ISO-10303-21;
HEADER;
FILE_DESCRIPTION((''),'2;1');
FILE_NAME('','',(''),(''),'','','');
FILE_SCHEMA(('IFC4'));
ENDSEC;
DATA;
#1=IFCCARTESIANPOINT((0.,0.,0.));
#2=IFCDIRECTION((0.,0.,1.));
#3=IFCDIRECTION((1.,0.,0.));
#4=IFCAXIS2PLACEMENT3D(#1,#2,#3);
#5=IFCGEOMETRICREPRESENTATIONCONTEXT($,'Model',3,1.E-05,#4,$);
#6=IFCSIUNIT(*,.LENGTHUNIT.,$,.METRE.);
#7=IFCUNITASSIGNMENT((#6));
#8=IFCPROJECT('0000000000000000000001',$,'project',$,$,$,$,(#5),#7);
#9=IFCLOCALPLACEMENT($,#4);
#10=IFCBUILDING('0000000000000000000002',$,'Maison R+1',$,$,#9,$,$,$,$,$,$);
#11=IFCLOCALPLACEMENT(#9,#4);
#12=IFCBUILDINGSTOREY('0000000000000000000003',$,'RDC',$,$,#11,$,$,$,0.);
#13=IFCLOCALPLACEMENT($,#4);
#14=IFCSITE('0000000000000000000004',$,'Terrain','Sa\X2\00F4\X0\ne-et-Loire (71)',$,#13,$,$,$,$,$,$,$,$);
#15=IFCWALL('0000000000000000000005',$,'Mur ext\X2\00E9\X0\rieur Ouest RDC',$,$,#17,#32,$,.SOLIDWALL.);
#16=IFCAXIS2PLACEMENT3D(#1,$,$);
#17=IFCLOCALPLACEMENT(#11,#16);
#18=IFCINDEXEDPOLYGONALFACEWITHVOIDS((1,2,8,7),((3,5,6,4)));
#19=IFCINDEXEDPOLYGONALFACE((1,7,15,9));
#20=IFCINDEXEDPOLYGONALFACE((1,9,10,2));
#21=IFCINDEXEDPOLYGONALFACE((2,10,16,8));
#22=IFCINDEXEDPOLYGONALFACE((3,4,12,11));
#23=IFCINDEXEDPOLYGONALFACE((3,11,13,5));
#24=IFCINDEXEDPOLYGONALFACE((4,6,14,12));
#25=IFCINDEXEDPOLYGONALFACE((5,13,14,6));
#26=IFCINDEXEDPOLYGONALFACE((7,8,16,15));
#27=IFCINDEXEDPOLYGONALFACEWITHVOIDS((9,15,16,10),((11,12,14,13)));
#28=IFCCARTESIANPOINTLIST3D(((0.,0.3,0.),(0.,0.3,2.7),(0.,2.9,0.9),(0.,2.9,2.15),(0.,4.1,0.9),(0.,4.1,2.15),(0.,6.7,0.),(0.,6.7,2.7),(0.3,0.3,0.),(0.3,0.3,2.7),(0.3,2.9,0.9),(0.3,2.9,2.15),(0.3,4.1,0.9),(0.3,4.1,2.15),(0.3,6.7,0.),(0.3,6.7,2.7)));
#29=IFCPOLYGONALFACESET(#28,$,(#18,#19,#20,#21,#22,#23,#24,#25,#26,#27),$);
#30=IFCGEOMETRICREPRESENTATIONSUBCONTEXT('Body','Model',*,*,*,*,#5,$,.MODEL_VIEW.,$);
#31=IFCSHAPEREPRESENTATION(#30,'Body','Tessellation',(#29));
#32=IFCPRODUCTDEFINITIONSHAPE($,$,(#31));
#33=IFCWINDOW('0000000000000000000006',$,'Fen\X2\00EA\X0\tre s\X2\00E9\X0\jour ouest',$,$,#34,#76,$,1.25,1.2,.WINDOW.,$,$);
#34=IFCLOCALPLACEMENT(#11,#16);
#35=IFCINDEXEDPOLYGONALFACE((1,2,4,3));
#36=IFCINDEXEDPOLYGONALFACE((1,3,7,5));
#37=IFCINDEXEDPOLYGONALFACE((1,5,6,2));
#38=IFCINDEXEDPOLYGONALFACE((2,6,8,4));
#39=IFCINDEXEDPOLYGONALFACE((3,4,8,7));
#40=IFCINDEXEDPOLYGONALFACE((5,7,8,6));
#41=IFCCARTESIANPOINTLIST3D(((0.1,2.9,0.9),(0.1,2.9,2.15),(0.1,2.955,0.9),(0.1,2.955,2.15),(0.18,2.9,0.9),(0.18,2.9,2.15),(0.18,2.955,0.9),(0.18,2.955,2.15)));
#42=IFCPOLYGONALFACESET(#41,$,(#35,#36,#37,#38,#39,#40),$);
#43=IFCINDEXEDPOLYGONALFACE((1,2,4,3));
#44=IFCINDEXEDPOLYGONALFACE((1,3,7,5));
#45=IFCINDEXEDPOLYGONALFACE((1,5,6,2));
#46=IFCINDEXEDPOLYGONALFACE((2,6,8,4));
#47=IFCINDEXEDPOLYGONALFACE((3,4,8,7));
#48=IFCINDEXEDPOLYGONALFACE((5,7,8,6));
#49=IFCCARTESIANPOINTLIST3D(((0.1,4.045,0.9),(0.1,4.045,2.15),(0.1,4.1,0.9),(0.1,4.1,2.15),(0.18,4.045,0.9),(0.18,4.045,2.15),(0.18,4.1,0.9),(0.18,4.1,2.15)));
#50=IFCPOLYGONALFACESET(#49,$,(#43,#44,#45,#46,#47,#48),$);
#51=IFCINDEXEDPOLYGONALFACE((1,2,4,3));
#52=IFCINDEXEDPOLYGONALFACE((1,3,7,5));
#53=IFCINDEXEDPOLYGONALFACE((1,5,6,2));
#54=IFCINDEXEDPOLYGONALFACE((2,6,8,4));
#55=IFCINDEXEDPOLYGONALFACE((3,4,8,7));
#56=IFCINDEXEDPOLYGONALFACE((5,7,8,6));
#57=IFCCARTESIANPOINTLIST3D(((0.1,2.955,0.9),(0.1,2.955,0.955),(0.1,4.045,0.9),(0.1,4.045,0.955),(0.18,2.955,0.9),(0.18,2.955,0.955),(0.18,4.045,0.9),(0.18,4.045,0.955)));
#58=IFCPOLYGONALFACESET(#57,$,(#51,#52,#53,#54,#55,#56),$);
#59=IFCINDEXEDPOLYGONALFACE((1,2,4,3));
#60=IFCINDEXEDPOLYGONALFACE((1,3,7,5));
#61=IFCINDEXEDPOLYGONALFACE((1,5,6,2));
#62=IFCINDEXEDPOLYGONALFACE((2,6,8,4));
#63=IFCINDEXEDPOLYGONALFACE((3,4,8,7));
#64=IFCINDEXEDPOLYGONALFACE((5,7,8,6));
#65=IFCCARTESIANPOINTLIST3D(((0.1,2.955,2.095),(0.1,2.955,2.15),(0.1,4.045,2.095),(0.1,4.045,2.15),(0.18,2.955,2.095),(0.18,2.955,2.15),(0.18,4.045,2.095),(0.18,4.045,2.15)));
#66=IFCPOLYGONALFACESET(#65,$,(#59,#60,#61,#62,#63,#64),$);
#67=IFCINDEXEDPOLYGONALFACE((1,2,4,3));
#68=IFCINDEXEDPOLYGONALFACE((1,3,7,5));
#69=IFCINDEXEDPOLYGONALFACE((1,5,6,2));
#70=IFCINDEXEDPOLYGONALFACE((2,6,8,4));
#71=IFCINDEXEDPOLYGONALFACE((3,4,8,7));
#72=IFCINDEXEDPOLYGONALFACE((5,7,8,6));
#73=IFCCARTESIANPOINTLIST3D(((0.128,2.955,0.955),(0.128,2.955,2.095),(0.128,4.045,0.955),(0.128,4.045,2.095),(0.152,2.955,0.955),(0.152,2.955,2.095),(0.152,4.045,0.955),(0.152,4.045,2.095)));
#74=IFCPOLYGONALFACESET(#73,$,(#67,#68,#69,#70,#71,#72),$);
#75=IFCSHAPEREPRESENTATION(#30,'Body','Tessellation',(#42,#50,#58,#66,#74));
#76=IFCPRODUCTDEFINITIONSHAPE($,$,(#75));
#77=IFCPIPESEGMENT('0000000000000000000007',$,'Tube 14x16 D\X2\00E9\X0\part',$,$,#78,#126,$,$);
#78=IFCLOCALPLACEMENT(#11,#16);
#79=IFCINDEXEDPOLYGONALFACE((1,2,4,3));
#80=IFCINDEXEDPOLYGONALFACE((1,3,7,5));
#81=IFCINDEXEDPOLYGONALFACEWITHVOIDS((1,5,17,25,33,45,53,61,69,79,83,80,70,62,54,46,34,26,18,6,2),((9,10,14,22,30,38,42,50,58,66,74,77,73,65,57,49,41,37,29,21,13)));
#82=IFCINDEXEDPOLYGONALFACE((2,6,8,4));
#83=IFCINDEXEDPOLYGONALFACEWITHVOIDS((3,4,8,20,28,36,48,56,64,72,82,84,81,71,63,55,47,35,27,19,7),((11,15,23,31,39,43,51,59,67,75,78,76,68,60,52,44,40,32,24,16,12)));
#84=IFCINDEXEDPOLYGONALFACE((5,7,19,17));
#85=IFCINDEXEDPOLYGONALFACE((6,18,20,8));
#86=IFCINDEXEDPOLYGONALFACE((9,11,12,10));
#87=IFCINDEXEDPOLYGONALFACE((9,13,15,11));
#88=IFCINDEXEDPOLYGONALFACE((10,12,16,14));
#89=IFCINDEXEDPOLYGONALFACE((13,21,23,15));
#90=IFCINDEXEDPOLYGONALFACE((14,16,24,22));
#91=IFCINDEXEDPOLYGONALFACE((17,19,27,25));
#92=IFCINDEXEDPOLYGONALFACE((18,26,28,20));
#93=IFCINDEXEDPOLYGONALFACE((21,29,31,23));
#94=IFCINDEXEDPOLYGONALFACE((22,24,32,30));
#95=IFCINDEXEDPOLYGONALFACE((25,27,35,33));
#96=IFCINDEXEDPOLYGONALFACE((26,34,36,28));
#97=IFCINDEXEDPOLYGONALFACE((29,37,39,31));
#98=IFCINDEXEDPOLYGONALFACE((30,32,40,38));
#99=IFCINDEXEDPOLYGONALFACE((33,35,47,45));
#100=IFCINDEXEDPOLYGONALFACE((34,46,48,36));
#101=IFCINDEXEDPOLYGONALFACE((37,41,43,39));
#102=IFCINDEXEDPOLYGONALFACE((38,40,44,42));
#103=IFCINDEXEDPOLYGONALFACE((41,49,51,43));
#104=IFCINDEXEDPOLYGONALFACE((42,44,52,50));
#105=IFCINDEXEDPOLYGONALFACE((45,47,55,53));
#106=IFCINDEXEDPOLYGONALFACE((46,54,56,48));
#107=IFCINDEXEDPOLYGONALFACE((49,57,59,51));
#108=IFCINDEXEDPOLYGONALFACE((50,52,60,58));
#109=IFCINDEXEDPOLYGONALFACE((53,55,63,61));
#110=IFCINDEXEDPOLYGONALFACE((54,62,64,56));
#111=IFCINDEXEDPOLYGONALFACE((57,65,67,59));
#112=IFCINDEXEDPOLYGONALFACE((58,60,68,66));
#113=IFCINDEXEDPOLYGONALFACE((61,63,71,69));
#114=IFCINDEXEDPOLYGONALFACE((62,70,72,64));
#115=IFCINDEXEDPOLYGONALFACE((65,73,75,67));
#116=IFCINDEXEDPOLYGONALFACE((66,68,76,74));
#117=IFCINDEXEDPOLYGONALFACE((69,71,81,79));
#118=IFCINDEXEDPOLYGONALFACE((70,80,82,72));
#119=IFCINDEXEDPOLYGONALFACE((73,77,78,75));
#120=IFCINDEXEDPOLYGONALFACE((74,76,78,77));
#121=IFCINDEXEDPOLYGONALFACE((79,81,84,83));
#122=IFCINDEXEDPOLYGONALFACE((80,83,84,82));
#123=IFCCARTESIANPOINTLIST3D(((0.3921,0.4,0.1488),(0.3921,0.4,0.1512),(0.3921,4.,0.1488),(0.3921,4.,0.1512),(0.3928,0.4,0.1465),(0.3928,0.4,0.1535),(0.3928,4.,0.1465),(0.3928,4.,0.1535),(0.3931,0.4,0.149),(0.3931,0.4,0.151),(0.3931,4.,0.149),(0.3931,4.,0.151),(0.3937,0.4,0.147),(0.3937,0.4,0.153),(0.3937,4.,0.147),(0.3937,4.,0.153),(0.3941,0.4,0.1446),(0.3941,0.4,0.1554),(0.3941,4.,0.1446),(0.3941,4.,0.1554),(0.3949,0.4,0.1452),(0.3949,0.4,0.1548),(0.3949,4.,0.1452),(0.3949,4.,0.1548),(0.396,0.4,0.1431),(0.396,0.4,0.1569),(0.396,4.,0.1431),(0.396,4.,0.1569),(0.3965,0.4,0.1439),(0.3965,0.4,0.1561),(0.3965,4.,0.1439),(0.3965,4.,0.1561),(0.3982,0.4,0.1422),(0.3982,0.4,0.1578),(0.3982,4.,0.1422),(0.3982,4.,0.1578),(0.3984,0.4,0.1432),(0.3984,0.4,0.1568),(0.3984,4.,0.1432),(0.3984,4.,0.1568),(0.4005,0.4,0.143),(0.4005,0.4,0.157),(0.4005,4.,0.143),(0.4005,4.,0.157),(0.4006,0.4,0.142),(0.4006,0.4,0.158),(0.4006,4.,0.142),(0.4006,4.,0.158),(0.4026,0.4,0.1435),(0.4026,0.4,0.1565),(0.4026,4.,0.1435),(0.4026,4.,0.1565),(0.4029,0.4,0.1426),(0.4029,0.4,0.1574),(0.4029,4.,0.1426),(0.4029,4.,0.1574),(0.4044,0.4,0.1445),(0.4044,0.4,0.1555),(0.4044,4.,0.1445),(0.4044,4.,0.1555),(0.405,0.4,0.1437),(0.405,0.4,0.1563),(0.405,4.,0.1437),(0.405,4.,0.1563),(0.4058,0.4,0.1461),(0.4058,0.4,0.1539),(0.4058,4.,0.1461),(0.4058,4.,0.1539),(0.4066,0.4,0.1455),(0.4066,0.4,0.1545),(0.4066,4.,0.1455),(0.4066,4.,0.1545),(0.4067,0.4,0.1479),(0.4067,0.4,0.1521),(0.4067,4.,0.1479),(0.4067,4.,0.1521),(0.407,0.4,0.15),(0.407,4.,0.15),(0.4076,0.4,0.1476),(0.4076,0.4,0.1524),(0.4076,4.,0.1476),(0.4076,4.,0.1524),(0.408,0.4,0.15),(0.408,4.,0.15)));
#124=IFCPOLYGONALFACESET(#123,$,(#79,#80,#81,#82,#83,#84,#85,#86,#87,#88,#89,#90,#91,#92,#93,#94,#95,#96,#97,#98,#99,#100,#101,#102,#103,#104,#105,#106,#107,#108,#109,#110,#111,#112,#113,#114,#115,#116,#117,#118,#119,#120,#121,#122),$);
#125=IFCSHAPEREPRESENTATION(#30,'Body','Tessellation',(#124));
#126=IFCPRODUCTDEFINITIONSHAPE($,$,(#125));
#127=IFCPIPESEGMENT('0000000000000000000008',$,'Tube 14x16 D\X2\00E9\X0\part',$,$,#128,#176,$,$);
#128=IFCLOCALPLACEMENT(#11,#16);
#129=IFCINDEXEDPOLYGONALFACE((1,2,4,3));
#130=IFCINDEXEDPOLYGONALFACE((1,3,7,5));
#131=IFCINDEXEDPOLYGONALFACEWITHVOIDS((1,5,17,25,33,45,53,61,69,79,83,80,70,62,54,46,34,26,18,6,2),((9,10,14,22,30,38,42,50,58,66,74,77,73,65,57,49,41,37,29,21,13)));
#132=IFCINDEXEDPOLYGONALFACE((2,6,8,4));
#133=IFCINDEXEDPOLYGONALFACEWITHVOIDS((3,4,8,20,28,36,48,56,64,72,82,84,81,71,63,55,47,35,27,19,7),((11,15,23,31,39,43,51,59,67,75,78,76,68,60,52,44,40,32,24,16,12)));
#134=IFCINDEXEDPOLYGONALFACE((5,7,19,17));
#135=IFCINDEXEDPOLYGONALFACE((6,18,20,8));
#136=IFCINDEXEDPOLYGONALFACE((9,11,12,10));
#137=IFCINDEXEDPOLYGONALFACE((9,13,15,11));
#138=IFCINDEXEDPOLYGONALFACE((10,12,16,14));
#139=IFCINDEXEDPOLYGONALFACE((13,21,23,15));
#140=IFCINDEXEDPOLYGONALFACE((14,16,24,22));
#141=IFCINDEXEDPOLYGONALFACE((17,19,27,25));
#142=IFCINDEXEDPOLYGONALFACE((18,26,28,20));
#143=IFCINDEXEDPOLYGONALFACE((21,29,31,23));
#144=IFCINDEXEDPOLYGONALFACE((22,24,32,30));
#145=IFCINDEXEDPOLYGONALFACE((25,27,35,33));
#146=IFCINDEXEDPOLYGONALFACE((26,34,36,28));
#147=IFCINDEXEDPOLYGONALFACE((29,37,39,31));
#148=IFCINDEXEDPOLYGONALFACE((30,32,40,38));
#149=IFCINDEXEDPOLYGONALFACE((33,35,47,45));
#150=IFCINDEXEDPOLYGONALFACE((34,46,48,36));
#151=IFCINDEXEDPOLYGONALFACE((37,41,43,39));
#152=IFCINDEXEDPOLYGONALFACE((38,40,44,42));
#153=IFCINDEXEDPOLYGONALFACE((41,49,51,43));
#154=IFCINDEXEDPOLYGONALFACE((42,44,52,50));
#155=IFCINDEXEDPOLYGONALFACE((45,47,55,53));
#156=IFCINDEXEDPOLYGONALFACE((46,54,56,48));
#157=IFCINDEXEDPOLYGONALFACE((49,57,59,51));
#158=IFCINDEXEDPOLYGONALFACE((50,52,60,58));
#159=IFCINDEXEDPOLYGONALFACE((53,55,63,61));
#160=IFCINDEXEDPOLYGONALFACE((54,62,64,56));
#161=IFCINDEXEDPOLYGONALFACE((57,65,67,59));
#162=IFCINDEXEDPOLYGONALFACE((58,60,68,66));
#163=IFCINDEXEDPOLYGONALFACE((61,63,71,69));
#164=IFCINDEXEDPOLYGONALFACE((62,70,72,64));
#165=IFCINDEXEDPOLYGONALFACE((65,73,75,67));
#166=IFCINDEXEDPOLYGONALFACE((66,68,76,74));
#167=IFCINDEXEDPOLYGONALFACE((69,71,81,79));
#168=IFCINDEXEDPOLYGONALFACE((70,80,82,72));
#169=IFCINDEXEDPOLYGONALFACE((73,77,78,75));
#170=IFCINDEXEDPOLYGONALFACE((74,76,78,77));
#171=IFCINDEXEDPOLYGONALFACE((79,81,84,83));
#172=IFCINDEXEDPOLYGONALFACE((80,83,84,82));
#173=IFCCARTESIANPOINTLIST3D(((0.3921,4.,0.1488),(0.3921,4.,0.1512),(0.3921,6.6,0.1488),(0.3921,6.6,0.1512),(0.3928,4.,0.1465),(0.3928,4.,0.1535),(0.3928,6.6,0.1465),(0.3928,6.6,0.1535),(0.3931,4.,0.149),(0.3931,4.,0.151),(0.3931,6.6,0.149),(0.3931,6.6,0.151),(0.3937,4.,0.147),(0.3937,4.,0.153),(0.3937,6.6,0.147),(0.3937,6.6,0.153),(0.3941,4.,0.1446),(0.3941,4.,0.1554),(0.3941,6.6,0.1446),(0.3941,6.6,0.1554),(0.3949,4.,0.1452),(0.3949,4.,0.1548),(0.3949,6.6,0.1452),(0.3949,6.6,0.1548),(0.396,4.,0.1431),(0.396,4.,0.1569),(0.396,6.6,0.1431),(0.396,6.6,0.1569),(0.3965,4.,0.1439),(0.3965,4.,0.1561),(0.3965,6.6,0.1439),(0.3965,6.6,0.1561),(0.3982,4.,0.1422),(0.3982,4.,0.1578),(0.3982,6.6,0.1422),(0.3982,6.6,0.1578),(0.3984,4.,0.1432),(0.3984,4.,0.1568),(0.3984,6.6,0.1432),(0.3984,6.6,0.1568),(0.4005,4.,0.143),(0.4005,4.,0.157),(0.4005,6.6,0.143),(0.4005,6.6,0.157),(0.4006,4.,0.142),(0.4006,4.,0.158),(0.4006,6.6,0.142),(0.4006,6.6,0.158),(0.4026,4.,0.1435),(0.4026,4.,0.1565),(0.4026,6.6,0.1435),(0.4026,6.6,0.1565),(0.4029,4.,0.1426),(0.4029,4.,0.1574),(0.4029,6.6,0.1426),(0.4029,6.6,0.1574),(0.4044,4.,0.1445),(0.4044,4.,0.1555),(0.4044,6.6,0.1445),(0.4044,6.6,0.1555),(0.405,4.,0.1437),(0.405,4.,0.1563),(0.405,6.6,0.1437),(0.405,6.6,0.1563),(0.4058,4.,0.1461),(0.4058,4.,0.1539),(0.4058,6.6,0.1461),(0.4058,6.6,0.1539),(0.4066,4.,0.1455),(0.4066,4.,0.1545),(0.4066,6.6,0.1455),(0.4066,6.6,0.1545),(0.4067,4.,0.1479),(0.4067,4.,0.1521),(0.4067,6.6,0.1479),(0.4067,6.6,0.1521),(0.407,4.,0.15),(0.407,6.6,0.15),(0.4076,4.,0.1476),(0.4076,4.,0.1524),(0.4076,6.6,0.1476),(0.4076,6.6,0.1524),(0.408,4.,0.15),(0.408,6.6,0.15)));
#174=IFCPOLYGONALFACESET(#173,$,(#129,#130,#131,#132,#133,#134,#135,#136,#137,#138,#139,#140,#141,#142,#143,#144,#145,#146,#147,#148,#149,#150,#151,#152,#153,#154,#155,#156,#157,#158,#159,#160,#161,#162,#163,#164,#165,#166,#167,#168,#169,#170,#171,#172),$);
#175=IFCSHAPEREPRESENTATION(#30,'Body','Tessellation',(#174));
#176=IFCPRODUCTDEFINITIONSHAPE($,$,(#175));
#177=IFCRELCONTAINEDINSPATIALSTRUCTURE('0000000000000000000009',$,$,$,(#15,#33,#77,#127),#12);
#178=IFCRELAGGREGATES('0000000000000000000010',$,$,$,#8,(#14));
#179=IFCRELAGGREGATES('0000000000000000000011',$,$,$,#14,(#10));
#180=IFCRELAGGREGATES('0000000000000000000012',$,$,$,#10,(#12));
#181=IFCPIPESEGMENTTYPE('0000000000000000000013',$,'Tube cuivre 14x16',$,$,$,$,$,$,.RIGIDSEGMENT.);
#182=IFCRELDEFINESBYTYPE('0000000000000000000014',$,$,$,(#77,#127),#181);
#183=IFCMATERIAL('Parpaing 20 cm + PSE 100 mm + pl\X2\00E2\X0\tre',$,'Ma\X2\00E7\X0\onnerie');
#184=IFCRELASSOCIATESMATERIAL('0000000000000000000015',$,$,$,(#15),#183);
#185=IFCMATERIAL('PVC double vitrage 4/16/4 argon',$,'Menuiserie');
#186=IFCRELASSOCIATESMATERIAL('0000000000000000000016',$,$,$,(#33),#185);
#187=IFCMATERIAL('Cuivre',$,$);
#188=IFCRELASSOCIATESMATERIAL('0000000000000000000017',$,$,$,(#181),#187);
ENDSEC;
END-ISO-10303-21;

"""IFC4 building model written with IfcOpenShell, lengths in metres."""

from ifc_helpers import new_model, si_unit, frame, frame_2d, origin_with_axes, place, context, subcontext, project, spatial, rectangle, hollow_circle, extrude, material, type_object, element, fill, save


model = new_model("IFC4")

# Units and contexts
model_context = context("Model", 3, precision=1e-05, world=origin_with_axes())
body_context = subcontext(model_context, "Body", "Model", "MODEL_VIEW")
ifc_project = project(units=[si_unit("LENGTHUNIT", "METRE")], contexts=[model_context])

# Site, building, storey
site_placement = place(None, origin_with_axes())
site = spatial("IfcSite", under=ifc_project, at=site_placement, Name="Terrain", Description="Saône-et-Loire (71)")
building_placement = place(None, origin_with_axes())
building = spatial("IfcBuilding", under=site, at=building_placement, Name="Maison R+1")
storey_placement = place(building_placement, origin_with_axes())
storey = spatial("IfcBuildingStorey", under=building, at=storey_placement, Name="RDC", Elevation=0.0)

# Shared definitions
ifc_material_1 = material(Name="Parpaing 20 cm + PSE 100 mm + plâtre", Category="Maçonnerie")
ifc_material_2 = material(Name="PVC double vitrage 4/16/4 argon", Category="Menuiserie")

# Wall, opening, window
wall_1_placement = place(storey_placement, frame((0.0, 0.3, 0.0), z_axis=(0.0, 0.0, 1.0), x_axis=(1.0, 0.0, 0.0)))
wall_1 = element("IfcWall", 1, at=wall_1_placement, inside=storey, material=ifc_material_1, Name="Mur extérieur Ouest RDC", PredefinedType="SOLIDWALL", context=body_context, shape_type="SweptSolid", body=[
    extrude(rectangle(XDim=0.3, YDim=6.4, at=frame_2d((0.15, 3.2))), origin_with_axes(), (0.0, 0.0, 1.0), 2.7),
])
opening_1_placement = place(storey_placement, frame((-0.05, 2.9, 0.9), z_axis=(0.0, 0.0, 1.0), x_axis=(1.0, 0.0, 0.0)))
opening_1 = element("IfcOpeningElement", 2, at=opening_1_placement, cuts=wall_1, context=body_context, shape_type="SweptSolid", body=[
    extrude(rectangle(XDim=0.4, YDim=1.2, at=frame_2d((0.2, 0.6))), origin_with_axes(), (0.0, 0.0, 1.0), 1.25),
])
window_1_placement = place(storey_placement, frame((0.1, 2.9, 0.9), z_axis=(0.0, 0.0, 1.0), x_axis=(1.0, 0.0, 0.0)))
window_1 = element("IfcWindow", 3, at=window_1_placement, inside=storey, material=ifc_material_2, Name="Fenêtre séjour ouest", OverallHeight=1.25, OverallWidth=1.2, PredefinedType="WINDOW", context=body_context, shape_type="SweptSolid", body=[
    extrude(rectangle(XDim=0.08, YDim=0.055, at=frame_2d((0.04, 0.0275))), origin_with_axes(), (0.0, 0.0, 1.0), 1.25),
    extrude(rectangle(XDim=0.08, YDim=0.055, at=frame_2d((0.04, 0.0275))), frame((0.0, 1.145, 0.0), z_axis=(0.0, 0.0, 1.0), x_axis=(1.0, 0.0, 0.0)), (0.0, 0.0, 1.0), 1.25),
    extrude(rectangle(XDim=0.08, YDim=1.09, at=frame_2d((0.04, 0.545))), frame((0.0, 0.055, 0.0), z_axis=(0.0, 0.0, 1.0), x_axis=(1.0, 0.0, 0.0)), (0.0, 0.0, 1.0), 0.055),
    extrude(rectangle(XDim=0.08, YDim=1.09, at=frame_2d((0.04, 0.545))), frame((0.0, 0.055, 1.195), z_axis=(0.0, 0.0, 1.0), x_axis=(1.0, 0.0, 0.0)), (0.0, 0.0, 1.0), 0.055),
    extrude(rectangle(XDim=0.024, YDim=1.09, at=frame_2d((0.012, 0.545))), frame((0.028, 0.055, 0.055), z_axis=(0.0, 0.0, 1.0), x_axis=(1.0, 0.0, 0.0)), (0.0, 0.0, 1.0), 1.14),
])
fill(opening_1, window_1)

# Pipe segments
ifc_material_3 = material(Name="Cuivre")
pipe_segment_type_1 = type_object("IfcPipeSegmentType", Name="Tube cuivre 14x16", PredefinedType="RIGIDSEGMENT", material=ifc_material_3)
pipe_segment_1_placement = place(storey_placement, frame((0.4, 0.4, 0.15), z_axis=(0.0, 1.0, 0.0), x_axis=(1.0, 0.0, 0.0)))
element("IfcPipeSegment", 4, at=pipe_segment_1_placement, inside=storey, type_object=pipe_segment_type_1, Name="Tube 14x16 Départ", context=body_context, shape_type="SweptSolid", body=[
    extrude(hollow_circle(Radius=0.008, WallThickness=0.001), origin_with_axes(), (0.0, 0.0, 1.0), 3.6),
])
pipe_segment_2_placement = place(storey_placement, frame((0.4, 4.0, 0.15), z_axis=(0.0, 1.0, 0.0), x_axis=(1.0, 0.0, 0.0)))
element("IfcPipeSegment", 5, at=pipe_segment_2_placement, inside=storey, type_object=pipe_segment_type_1, Name="Tube 14x16 Départ", context=body_context, shape_type="SweptSolid", body=[
    extrude(hollow_circle(Radius=0.008, WallThickness=0.001), origin_with_axes(), (0.0, 0.0, 1.0), 2.6),
])

save(model, "model.ifc")
